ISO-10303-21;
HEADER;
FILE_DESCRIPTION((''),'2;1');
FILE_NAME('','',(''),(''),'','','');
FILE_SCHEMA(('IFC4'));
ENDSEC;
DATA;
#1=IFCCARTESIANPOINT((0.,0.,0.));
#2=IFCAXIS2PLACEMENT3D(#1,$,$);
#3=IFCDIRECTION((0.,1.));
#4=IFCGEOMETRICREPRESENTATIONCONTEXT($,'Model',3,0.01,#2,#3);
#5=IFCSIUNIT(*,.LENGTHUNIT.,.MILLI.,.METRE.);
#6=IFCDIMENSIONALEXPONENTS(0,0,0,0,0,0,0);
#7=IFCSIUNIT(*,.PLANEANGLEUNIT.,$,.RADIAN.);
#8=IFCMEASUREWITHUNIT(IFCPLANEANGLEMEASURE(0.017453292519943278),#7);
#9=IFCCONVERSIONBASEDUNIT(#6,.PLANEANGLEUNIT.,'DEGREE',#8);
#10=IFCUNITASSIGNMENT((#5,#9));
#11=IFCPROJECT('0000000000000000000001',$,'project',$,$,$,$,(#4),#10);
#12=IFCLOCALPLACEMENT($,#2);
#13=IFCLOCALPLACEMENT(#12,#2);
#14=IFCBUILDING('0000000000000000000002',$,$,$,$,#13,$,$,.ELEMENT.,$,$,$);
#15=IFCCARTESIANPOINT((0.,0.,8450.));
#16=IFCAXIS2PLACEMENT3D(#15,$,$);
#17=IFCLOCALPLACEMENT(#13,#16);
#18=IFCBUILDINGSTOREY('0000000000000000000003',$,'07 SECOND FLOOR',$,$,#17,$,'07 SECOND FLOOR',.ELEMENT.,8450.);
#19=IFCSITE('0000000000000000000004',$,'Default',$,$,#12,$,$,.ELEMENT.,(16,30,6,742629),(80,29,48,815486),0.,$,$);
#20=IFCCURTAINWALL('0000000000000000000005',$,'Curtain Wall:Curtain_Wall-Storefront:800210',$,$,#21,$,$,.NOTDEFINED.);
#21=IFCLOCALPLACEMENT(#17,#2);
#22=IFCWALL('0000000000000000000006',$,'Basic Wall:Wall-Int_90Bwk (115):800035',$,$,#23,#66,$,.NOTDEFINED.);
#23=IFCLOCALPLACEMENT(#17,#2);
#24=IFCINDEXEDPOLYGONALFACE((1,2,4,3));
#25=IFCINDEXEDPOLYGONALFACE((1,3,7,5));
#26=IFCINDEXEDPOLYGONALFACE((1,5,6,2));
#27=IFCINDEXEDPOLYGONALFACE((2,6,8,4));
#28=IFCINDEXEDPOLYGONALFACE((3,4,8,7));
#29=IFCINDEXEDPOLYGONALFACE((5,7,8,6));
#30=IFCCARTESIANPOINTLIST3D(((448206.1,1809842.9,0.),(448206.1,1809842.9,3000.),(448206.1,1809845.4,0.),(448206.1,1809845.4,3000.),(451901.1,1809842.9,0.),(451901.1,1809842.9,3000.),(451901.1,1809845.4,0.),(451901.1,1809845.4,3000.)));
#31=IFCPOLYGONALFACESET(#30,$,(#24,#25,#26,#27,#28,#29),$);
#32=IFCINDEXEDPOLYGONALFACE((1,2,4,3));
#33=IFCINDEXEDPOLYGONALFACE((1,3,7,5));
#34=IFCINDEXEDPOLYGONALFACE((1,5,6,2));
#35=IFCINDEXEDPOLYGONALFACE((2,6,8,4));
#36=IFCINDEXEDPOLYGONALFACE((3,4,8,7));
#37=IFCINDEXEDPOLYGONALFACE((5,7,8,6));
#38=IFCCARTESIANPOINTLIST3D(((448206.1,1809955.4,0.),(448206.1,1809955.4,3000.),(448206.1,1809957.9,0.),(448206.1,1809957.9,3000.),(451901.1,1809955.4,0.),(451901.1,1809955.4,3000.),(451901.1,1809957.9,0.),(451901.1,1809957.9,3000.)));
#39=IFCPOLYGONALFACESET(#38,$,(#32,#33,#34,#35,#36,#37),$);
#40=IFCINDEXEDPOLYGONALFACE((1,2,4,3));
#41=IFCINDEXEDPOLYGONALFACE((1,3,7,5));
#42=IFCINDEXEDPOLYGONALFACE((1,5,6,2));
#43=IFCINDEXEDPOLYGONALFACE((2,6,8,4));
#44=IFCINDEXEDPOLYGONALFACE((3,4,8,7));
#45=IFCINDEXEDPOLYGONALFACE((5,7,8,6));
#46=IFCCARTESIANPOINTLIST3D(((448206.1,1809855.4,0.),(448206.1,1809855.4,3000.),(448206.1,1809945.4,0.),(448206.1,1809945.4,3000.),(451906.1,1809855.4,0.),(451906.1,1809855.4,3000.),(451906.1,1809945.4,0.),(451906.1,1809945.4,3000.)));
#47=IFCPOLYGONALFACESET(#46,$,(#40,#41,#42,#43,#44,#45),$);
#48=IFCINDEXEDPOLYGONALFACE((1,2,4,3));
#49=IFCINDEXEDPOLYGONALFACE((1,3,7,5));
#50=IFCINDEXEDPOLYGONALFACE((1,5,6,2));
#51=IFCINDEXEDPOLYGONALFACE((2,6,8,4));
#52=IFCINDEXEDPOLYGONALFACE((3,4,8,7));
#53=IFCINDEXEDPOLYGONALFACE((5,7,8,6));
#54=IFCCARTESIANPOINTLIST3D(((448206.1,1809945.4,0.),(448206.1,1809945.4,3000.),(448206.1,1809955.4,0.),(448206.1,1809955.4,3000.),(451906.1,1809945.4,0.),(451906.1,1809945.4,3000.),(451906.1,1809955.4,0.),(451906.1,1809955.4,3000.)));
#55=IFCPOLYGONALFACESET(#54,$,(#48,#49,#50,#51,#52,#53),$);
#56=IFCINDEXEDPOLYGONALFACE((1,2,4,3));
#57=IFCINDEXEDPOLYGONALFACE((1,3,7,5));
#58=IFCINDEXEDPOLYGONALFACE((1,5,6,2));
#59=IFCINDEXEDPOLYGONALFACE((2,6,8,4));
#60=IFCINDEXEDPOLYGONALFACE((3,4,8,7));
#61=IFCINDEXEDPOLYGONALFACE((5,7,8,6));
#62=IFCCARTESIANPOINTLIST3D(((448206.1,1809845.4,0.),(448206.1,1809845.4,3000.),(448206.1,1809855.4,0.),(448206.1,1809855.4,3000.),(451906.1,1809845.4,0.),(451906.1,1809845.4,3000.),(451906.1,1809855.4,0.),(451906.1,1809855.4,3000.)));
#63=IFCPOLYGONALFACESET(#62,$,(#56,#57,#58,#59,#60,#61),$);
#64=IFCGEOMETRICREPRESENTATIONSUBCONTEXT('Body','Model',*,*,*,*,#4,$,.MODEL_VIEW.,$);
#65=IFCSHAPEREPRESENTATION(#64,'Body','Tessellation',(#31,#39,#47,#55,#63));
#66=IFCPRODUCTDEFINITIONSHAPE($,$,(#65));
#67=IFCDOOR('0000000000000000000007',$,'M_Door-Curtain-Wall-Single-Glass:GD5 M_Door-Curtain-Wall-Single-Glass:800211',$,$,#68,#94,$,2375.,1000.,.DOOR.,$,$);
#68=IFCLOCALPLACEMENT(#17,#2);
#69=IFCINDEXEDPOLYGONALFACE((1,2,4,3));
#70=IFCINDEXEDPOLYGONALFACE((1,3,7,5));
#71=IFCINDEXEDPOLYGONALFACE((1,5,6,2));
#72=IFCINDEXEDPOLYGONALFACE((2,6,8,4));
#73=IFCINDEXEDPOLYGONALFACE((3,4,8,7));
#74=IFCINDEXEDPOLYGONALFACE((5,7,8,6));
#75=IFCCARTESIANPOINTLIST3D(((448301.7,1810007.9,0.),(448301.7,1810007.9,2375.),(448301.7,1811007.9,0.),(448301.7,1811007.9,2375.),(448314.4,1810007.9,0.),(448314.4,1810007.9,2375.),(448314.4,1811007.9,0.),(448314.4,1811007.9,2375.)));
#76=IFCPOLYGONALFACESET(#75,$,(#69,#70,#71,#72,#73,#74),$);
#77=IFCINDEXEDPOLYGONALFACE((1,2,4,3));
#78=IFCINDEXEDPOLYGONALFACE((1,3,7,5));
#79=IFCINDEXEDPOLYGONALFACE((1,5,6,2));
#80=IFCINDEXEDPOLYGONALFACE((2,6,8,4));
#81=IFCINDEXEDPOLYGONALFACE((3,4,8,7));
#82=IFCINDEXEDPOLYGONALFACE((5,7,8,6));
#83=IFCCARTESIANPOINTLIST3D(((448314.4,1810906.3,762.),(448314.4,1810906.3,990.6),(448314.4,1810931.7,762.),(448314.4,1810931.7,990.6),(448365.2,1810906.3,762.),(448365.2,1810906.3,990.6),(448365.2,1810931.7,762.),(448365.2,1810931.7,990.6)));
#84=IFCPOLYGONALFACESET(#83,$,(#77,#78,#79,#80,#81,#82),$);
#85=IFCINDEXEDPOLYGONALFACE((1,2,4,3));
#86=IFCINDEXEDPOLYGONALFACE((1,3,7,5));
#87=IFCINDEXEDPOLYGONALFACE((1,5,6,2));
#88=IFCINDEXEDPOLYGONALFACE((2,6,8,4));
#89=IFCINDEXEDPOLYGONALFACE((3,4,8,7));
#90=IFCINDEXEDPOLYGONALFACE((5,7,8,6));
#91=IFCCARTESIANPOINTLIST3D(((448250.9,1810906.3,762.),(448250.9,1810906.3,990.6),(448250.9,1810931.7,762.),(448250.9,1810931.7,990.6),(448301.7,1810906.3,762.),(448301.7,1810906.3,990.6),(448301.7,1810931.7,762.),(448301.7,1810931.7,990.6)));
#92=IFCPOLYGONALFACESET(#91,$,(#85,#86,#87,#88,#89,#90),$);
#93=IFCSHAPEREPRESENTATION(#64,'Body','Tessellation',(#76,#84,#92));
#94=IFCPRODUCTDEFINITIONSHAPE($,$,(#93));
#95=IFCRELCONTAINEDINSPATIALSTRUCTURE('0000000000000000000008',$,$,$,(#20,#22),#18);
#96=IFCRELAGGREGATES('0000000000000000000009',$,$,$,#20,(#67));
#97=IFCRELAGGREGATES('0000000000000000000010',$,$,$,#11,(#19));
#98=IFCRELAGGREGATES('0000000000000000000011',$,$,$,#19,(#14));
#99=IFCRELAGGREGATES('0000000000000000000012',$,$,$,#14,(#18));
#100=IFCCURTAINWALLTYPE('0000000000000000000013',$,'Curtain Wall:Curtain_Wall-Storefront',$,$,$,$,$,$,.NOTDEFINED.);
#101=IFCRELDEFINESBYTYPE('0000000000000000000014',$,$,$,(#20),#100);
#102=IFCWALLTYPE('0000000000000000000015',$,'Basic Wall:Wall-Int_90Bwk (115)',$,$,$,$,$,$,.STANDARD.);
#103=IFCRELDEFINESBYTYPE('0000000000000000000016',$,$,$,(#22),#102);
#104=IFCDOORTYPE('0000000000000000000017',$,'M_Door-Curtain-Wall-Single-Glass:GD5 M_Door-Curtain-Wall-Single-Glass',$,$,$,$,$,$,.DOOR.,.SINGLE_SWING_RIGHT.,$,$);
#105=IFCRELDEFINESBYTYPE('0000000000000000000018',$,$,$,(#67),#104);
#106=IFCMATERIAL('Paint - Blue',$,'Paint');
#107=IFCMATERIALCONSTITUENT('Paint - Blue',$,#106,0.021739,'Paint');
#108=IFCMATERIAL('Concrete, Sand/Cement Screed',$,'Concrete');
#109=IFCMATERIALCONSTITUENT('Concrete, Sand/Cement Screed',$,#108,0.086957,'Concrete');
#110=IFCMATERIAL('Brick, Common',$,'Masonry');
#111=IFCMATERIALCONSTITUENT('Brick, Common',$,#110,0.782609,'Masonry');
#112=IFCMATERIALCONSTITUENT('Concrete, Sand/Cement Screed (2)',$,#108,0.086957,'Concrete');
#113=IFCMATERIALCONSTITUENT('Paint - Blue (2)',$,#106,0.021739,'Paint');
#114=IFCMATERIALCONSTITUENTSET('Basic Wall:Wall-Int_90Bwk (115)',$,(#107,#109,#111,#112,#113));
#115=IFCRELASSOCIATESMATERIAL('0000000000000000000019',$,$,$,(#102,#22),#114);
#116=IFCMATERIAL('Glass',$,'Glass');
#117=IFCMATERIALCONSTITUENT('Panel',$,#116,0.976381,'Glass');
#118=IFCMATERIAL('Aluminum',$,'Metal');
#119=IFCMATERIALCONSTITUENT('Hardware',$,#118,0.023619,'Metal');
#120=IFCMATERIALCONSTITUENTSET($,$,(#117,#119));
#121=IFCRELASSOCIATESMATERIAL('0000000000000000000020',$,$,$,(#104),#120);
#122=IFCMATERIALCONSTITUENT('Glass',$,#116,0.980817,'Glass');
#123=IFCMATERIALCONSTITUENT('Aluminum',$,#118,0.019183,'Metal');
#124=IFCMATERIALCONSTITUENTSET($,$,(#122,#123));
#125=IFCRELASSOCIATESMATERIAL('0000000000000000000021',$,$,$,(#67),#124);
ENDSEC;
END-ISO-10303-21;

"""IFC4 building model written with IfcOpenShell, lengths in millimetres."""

from ifc_helpers import new_model, entity, si_unit, converted_unit, direction, frame, origin, place, context, subcontext, project, spatial, indexed_curve, outline, extrude, source, transform, mapped, material, constituent, constituent_set, type_object, type_shapes, element, aggregate, save


model = new_model("IFC4")

# Units and contexts
model_context = context("Model", 3, precision=0.01, world=origin(), true_north=direction((0.0, 1.0)))
body_context = subcontext(model_context, "Body", "Model", "MODEL_VIEW")
ifc_project = project(units=[si_unit("LENGTHUNIT", "METRE", prefix="MILLI"), converted_unit("PLANEANGLEUNIT", "DEGREE", entity("IfcPlaneAngleMeasure", 0.017453292519943278), si_unit("PLANEANGLEUNIT", "RADIAN"), dimensions=[0, 0, 0, 0, 0, 0, 0])], contexts=[model_context])

# Site, building, storey
site_placement = place(None, origin())
site = spatial("IfcSite", under=ifc_project, at=site_placement, Name="Default", CompositionType="ELEMENT", RefLatitude=(16, 30, 6, 742629), RefLongitude=(80, 29, 48, 815486), RefElevation=0.0)
building_placement = place(site_placement, origin())
building = spatial("IfcBuilding", under=site, at=building_placement, CompositionType="ELEMENT")
storey_placement = place(building_placement, frame((0.0, 0.0, 8450.0)))
storey = spatial("IfcBuildingStorey", under=building, at=storey_placement, Name="07 SECOND FLOOR", LongName="07 SECOND FLOOR", CompositionType="ELEMENT", Elevation=8450.0)

# Shared definitions
curtain_wall_type = type_object("IfcCurtainWallType", Name="Curtain Wall:Curtain_Wall-Storefront", PredefinedType="NOTDEFINED")

# Curtain wall
curtain_wall_1_placement = place(storey_placement, frame((0.0, 0.0, -8450.0)))
curtain_wall_1 = element("IfcCurtainWall", 1, at=curtain_wall_1_placement, inside=storey, type_object=curtain_wall_type, Name="Curtain Wall:Curtain_Wall-Storefront:800210", PredefinedType="NOTDEFINED")

# Shared definitions
ifc_material_1 = material(Name="Glass", Category="Glass")

# Wall
ifc_material_2 = material(Name="Paint - Blue", Category="Paint")
ifc_constituent_1 = constituent(ifc_material_2, Name="Paint - Blue", Category="Paint", fraction=0.021739)
ifc_material_3 = material(Name="Concrete, Sand/Cement Screed", Category="Concrete")
ifc_constituent_2 = constituent(ifc_material_3, Name="Concrete, Sand/Cement Screed", Category="Concrete", fraction=0.086957)
ifc_material_4 = material(Name="Brick, Common", Category="Masonry")
ifc_constituent_3 = constituent(ifc_material_4, Name="Brick, Common", Category="Masonry", fraction=0.782609)
ifc_constituent_4 = constituent(ifc_material_3, Name="Concrete, Sand/Cement Screed (2)", Category="Concrete", fraction=0.086957)
ifc_constituent_5 = constituent(ifc_material_2, Name="Paint - Blue (2)", Category="Paint", fraction=0.021739)
ifc_constituent_set_1 = constituent_set(constituents=[ifc_constituent_1, ifc_constituent_2, ifc_constituent_3, ifc_constituent_4, ifc_constituent_5], Name="Basic Wall:Wall-Int_90Bwk (115)")
wall_type = type_object("IfcWallType", Name="Basic Wall:Wall-Int_90Bwk (115)", PredefinedType="STANDARD", material=ifc_constituent_set_1)
wall_placement = place(storey_placement, frame((448206.1, 1809900.4, 0.0)))
element("IfcWall", 2, at=wall_placement, inside=storey, type_object=wall_type, material=ifc_constituent_set_1, Name="Basic Wall:Wall-Int_90Bwk (115):800035", PredefinedType="NOTDEFINED", context=body_context, shape_type="SweptSolid", body=[
    extrude(outline(indexed_curve([(-1.2, -1847.5), (1.3, -1847.5), (1.3, 1847.5), (-1.2, 1847.5), (-1.2, -1847.5)], self_intersect=False)), frame((1847.5, -56.3, 0.0), z_axis=(0.0, 0.0, 1.0), x_axis=(0.0, 1.0, 0.0)), (0.0, 0.0, 1.0), 3000.0),
    extrude(outline(indexed_curve([(-1.3, -1847.5), (1.3, -1847.5), (1.3, 1847.5), (-1.3, 1847.5), (-1.3, -1847.5)], self_intersect=False)), frame((1847.5, 56.3, 0.0), z_axis=(0.0, 0.0, 1.0), x_axis=(0.0, -1.0, 0.0)), (0.0, 0.0, 1.0), 3000.0),
    extrude(outline(indexed_curve([(-1850.0, -45.0), (1850.0, -45.0), (1850.0, 45.0), (-1850.0, 45.0), (-1850.0, -45.0)], self_intersect=False)), frame((1850.0, 0.0, 0.0)), (0.0, 0.0, 1.0), 3000.0),
    extrude(outline(indexed_curve([(-1850.0, -5.0), (1850.0, -5.0), (1850.0, 5.0), (-1850.0, 5.0), (-1850.0, -5.0)], self_intersect=False)), frame((1850.0, 50.0, 0.0)), (0.0, 0.0, 1.0), 3000.0),
    extrude(outline(indexed_curve([(-1850.0, -5.0), (1850.0, -5.0), (1850.0, 5.0), (-1850.0, 5.0), (-1850.0, -5.0)], self_intersect=False)), frame((1850.0, -50.0, 0.0)), (0.0, 0.0, 1.0), 3000.0),
])

# Door
ifc_constituent_6 = constituent(ifc_material_1, Name="Glass", Category="Glass", fraction=0.980817)
ifc_material_5 = material(Name="Aluminum", Category="Metal")
ifc_constituent_7 = constituent(ifc_material_5, Name="Aluminum", Category="Metal", fraction=0.019183)
ifc_constituent_set_2 = constituent_set(constituents=[ifc_constituent_6, ifc_constituent_7])
ifc_constituent_8 = constituent(ifc_material_1, Name="Panel", Category="Glass", fraction=0.976381)
ifc_constituent_9 = constituent(ifc_material_5, Name="Hardware", Category="Metal", fraction=0.023619)
ifc_constituent_set_3 = constituent_set(constituents=[ifc_constituent_8, ifc_constituent_9])
door_type = type_object("IfcDoorType", Name="M_Door-Curtain-Wall-Single-Glass:GD5 M_Door-Curtain-Wall-Single-Glass", OperationType="SINGLE_SWING_RIGHT", PredefinedType="DOOR", material=ifc_constituent_set_3)
shared_shape_1 = source(origin(), body_context, "Body", "SweptSolid", [
    extrude(outline(indexed_curve([(-500.0, -6.4), (500.0, -6.4), (500.0, 6.4), (-500.0, 6.4), (-500.0, -6.4)], self_intersect=False)), frame((0.0, 44.5, 0.0), z_axis=(0.0, 0.0, 1.0), x_axis=(-1.0, 0.0, 0.0)), (0.0, 0.0, 1.0), 2375.0),
    extrude(outline(indexed_curve([(-25.4, -12.7), (25.4, -12.7), (25.4, 12.7), (-25.4, 12.7), (-25.4, -12.7)], self_intersect=False)), frame((-411.1, 76.2, 762.0), z_axis=(0.0, 0.0, 1.0), x_axis=(0.0, -1.0, 0.0)), (0.0, 0.0, 1.0), 228.6),
    extrude(outline(indexed_curve([(-25.4, -12.7), (25.4, -12.7), (25.4, 12.7), (-25.4, 12.7), (-25.4, -12.7)], self_intersect=False)), frame((-411.1, 12.7, 762.0), z_axis=(0.0, 0.0, 1.0), x_axis=(0.0, 1.0, 0.0)), (0.0, 0.0, 1.0), 228.6),
])
type_shapes(door_type, [shared_shape_1])
door_placement = place(curtain_wall_1_placement, frame((448263.6, 1810507.9, 8450.0), z_axis=(0.0, 0.0, 1.0), x_axis=(0.0, -1.0, 0.0)))
door = element("IfcDoor", 3, at=door_placement, type_object=door_type, material=ifc_constituent_set_2, Name="M_Door-Curtain-Wall-Single-Glass:GD5 M_Door-Curtain-Wall-Single-Glass:800211", OverallHeight=2375.0, OverallWidth=1000.0, PredefinedType="DOOR", context=body_context, shape_type="MappedRepresentation", body=[
    mapped(shared_shape_1, transform((0.0, 0.0, 0.0), scale=1.0)),
])
aggregate(curtain_wall_1, [door])

save(model, "model.ifc")
